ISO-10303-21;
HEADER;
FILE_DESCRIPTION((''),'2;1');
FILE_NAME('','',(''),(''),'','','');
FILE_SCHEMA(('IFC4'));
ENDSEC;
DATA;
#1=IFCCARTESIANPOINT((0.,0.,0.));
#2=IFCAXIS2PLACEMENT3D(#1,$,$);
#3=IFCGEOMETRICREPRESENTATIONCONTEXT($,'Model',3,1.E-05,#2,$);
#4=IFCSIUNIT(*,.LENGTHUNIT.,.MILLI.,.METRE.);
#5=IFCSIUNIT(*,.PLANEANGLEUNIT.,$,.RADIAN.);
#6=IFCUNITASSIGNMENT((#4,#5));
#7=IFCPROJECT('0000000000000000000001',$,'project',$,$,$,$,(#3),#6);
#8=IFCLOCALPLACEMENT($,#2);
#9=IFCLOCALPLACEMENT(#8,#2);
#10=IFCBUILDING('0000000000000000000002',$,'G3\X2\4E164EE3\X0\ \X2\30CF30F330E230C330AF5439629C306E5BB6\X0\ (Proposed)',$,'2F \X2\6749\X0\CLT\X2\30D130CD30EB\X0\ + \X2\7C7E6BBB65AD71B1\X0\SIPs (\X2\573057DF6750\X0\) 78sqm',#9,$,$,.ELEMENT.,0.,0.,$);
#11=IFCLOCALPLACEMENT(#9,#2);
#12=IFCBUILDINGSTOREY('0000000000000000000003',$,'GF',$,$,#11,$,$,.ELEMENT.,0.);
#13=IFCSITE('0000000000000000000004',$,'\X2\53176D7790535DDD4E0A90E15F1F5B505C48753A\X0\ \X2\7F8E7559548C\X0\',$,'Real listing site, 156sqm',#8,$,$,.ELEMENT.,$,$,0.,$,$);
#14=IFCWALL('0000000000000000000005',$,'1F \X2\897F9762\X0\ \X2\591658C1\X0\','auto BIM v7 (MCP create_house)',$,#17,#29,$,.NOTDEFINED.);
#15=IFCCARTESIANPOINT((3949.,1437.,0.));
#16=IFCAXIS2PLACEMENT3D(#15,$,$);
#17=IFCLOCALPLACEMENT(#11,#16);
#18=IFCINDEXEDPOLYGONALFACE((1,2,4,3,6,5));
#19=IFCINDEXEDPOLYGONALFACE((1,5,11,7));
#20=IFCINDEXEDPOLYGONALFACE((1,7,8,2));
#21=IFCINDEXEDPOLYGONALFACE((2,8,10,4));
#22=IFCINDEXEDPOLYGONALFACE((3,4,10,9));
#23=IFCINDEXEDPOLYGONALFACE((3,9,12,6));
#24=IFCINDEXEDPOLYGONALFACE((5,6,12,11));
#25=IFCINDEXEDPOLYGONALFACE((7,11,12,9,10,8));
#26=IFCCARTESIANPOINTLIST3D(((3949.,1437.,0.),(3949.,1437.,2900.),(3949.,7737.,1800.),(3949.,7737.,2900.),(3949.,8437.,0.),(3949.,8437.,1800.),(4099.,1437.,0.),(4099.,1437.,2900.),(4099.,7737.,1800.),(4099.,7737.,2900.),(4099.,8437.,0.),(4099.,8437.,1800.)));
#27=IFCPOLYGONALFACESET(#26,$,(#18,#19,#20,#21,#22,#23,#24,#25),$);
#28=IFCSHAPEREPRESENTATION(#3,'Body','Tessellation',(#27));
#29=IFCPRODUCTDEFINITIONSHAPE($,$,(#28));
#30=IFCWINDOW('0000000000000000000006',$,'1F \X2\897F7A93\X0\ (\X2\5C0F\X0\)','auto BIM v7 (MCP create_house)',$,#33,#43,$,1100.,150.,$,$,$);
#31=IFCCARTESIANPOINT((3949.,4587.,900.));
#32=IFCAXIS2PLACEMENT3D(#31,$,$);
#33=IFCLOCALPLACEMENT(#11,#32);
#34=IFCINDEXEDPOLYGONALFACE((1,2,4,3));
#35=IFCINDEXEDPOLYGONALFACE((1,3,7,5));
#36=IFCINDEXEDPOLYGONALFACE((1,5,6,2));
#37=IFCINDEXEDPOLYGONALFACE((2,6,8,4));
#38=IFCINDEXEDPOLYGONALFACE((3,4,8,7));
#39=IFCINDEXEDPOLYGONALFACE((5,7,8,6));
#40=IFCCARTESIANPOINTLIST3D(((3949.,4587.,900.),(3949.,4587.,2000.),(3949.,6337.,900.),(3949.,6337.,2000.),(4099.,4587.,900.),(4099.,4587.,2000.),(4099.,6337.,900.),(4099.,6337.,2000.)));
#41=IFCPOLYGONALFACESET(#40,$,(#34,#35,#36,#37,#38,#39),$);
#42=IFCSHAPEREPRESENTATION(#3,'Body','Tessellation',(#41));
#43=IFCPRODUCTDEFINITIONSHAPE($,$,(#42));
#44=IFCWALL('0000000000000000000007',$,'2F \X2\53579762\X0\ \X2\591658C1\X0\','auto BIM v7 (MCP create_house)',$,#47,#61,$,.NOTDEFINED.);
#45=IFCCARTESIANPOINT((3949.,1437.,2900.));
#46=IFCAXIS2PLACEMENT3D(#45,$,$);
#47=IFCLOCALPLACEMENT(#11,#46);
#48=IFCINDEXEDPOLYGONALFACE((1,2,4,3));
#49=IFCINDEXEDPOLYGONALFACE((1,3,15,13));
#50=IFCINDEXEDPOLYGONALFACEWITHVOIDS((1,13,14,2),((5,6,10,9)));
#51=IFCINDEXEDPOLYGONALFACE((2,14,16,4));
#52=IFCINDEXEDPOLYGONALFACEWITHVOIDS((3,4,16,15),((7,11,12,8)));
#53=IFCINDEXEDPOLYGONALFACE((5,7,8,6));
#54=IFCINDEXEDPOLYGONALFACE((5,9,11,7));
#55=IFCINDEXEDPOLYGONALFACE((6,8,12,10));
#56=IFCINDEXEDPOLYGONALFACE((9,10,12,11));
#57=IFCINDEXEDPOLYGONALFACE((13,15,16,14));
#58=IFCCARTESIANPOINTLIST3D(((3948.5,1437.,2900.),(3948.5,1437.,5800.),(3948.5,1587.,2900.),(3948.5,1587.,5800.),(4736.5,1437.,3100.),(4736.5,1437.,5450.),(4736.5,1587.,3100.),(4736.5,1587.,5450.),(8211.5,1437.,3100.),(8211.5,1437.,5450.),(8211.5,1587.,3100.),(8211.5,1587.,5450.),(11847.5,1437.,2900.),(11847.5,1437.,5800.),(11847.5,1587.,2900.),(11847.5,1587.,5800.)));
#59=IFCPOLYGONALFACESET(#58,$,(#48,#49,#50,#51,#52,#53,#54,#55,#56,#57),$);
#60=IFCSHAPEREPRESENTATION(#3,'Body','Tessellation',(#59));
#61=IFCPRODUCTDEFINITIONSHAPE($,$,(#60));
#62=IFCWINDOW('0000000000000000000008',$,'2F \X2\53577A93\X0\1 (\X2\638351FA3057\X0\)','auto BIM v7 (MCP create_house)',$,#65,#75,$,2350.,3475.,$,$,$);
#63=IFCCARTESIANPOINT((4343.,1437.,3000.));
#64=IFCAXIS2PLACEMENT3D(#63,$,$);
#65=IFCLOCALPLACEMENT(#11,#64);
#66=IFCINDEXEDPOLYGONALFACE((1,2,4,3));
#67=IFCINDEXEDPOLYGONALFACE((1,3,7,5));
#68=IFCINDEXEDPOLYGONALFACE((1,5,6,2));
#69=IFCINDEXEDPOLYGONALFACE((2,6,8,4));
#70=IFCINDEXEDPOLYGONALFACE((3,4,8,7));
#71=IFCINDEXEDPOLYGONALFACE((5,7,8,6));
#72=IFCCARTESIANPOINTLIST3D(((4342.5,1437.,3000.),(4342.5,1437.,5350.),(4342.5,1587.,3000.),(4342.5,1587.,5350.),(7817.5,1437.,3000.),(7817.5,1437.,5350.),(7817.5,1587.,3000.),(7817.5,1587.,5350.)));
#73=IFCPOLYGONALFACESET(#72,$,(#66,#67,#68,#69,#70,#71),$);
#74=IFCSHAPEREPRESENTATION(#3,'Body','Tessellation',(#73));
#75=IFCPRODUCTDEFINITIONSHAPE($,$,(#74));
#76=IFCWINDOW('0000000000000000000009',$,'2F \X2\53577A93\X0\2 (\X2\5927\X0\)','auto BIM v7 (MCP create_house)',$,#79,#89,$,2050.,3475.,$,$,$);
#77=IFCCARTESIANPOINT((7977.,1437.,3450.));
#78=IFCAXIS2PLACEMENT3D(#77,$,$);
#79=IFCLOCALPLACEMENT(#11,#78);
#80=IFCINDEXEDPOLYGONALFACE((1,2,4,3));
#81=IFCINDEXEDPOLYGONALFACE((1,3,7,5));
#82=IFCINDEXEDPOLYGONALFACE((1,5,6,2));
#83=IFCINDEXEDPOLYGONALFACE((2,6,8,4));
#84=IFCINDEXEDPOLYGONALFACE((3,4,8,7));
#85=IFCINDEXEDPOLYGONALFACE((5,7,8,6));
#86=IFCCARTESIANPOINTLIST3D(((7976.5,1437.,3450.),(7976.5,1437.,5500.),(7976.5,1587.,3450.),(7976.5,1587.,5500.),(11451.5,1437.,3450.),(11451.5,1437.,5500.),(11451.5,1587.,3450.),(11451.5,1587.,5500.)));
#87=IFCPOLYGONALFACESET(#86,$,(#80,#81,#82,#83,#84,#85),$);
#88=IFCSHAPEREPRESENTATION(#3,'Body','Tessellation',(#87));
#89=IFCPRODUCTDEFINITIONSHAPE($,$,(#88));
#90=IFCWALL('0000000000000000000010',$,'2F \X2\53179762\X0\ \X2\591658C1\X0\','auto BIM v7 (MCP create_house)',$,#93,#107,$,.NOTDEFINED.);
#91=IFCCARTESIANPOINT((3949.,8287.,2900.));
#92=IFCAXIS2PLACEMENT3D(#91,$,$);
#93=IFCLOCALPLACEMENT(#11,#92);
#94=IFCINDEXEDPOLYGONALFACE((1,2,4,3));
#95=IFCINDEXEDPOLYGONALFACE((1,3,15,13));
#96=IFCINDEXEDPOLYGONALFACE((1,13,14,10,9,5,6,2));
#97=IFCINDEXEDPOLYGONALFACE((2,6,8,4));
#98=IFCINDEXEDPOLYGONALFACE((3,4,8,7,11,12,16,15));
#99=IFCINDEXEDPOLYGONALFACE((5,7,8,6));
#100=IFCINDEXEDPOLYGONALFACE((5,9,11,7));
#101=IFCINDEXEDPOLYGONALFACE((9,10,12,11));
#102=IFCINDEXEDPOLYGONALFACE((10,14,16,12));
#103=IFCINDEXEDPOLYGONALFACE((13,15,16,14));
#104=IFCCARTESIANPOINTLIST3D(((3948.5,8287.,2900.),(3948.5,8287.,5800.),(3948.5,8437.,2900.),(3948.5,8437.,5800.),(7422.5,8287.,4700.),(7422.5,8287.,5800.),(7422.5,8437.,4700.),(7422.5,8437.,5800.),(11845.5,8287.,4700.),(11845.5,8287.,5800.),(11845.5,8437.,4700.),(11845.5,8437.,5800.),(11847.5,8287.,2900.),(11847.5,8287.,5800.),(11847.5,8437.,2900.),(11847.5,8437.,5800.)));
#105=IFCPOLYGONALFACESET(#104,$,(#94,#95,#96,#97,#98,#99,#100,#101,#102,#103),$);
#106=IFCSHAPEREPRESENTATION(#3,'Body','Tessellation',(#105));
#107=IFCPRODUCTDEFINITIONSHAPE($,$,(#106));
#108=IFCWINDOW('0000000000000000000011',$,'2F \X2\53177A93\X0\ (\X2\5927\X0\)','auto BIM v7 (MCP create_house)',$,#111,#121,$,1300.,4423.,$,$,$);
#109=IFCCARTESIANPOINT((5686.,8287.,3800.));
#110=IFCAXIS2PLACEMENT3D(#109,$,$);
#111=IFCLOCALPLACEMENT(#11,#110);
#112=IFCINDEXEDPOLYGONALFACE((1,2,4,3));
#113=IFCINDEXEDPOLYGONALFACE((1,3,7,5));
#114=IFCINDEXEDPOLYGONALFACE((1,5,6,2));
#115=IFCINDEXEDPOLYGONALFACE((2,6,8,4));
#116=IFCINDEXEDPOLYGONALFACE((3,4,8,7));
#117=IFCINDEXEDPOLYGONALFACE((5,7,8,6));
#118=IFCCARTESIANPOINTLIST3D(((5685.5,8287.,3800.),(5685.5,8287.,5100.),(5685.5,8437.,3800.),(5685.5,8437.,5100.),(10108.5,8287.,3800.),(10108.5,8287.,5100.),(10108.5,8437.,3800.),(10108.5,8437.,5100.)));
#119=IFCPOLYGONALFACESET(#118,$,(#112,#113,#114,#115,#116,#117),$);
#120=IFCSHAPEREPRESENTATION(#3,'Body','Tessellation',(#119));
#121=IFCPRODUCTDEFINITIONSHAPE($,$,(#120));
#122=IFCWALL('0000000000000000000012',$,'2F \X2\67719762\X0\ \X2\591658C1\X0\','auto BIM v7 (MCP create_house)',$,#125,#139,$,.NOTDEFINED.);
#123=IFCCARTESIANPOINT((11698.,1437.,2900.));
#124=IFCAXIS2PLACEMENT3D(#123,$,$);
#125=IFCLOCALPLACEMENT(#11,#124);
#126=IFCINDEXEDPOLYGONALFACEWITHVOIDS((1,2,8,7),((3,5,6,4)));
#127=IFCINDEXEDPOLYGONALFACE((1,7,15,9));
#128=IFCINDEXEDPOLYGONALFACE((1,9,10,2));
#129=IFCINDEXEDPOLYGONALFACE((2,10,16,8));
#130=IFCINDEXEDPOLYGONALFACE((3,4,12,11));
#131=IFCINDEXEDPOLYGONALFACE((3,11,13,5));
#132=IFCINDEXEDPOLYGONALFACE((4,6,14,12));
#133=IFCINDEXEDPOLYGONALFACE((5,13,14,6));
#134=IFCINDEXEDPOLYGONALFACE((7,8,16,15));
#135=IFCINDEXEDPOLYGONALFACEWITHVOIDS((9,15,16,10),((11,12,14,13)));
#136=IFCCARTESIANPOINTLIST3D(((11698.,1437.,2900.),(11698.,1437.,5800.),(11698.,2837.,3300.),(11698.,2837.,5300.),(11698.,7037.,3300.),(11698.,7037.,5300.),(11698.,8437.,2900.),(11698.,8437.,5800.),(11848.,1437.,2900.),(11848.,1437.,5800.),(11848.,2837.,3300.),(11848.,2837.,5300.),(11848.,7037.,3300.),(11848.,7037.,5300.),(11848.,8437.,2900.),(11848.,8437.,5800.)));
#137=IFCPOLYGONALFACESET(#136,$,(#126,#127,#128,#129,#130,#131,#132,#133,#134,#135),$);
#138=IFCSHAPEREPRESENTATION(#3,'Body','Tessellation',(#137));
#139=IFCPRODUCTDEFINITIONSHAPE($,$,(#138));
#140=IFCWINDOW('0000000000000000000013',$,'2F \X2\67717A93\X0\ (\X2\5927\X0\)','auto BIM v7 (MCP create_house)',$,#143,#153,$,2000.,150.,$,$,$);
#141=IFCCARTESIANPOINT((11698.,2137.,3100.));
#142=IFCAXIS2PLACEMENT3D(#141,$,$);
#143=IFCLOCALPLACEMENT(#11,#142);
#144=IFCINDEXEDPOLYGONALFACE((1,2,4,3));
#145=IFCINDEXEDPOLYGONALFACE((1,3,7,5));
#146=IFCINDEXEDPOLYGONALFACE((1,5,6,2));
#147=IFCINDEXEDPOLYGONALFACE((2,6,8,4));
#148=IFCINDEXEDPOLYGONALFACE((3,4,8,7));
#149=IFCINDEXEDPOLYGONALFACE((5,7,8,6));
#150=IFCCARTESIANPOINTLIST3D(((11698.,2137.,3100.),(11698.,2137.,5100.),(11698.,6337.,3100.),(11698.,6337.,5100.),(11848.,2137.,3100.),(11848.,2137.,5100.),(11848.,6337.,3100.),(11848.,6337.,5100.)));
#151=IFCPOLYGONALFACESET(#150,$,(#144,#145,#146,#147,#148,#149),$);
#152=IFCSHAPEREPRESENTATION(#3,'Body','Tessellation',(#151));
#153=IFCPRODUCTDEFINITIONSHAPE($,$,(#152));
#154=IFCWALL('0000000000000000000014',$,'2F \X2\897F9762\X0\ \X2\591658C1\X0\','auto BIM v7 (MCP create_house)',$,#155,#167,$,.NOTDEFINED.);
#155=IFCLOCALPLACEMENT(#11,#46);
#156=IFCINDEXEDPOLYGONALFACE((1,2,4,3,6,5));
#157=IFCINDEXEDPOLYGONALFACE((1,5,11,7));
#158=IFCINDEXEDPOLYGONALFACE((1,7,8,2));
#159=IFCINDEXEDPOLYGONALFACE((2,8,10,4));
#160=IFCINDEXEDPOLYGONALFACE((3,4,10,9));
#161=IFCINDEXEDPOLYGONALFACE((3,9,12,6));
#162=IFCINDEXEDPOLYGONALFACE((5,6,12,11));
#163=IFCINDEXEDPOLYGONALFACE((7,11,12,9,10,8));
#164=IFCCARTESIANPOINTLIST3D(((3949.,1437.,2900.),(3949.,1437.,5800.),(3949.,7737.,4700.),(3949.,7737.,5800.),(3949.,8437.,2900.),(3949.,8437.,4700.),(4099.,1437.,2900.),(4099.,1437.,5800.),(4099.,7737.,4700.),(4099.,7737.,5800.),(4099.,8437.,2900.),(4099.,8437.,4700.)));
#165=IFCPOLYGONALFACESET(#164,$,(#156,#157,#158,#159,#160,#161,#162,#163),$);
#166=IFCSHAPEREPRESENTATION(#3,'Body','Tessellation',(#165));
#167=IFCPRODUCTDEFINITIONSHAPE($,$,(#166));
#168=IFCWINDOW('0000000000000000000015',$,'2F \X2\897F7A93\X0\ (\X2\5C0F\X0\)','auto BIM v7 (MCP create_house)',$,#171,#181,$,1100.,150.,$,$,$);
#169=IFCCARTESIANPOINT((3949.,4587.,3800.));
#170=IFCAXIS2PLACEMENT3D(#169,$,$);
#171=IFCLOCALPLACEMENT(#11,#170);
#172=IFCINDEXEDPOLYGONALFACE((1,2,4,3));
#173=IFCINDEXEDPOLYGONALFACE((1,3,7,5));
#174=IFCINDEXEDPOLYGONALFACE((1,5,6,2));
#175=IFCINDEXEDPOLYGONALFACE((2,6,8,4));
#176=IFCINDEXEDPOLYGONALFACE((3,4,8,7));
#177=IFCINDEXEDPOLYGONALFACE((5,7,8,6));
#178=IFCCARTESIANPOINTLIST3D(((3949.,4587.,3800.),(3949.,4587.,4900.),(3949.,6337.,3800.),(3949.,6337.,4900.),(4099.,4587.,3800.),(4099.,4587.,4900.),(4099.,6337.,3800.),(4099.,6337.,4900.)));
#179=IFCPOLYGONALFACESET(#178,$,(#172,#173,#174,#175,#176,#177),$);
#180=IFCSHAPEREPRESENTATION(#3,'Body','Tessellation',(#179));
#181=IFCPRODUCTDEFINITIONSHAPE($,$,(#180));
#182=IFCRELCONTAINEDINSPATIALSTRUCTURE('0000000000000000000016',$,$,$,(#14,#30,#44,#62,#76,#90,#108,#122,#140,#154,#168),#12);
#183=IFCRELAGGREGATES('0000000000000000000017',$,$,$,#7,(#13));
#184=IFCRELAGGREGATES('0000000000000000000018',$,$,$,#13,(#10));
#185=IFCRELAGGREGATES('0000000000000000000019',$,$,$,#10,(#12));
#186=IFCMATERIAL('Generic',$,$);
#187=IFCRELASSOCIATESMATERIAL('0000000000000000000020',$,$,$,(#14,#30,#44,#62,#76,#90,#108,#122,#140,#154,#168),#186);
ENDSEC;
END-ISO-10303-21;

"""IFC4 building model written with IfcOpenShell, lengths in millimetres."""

from ifc_helpers import new_model, si_unit, frame, frame_2d, origin, place, context, project, spatial, rectangle, extrude, material, element, fill, save


model = new_model("IFC4")

# Units and contexts
model_context = context("Model", 3, precision=1e-05, world=origin())
ifc_project = project(units=[si_unit("LENGTHUNIT", "METRE", prefix="MILLI"), si_unit("PLANEANGLEUNIT", "RADIAN")], contexts=[model_context])

# Site, building, storey
site_placement = place(None, origin())
site = spatial("IfcSite", under=ifc_project, at=site_placement, Name="北海道川上郡弟子屈町 美留和", ObjectType="Real listing site, 156sqm", CompositionType="ELEMENT", RefElevation=0.0)
building_placement = place(site_placement, origin())
building = spatial("IfcBuilding", under=site, at=building_placement, Name="G3世代 ハンモック吹抜の家 (Proposed)", ObjectType="2F 杉CLTパネル + 籾殻断熱SIPs (地域材) 78sqm", CompositionType="ELEMENT", ElevationOfRefHeight=0.0, ElevationOfTerrain=0.0)
storey_placement = place(building_placement, origin())
storey = spatial("IfcBuildingStorey", under=building, at=storey_placement, Name="GF", CompositionType="ELEMENT", Elevation=0.0)

# Shared definitions
ifc_material = material(Name="Generic")

# Wall, opening, window
wall_1_placement = place(storey_placement, frame((3949.0, 1437.0, 0.0)))
wall_1 = element("IfcWall", 1, at=wall_1_placement, inside=storey, material=ifc_material, Name="1F 西面 外壁", Description="auto BIM v7 (MCP create_house)", PredefinedType="NOTDEFINED", context=model_context, shape_type="SweptSolid", body=[
    extrude(rectangle(XDim=150.0, YDim=7000.0, at=frame_2d((75.0, 3500.0))), frame((3949.0, 1437.0, 0.0)), (0.0, 0.0, 1.0), 2900.0),
])
opening_1_placement = place(storey_placement, frame((3949.0, 4587.0, 900.0)))
opening_1 = element("IfcOpeningElement", 2, at=opening_1_placement, cuts=wall_1, PredefinedType="NOTDEFINED", context=model_context, shape_type="SweptSolid", body=[
    extrude(rectangle(XDim=150.0, YDim=1750.0, at=frame_2d((75.0, 875.0))), frame((3949.0, 4587.0, 900.0)), (0.0, 0.0, 1.0), 1100.0),
])
window_1_placement = place(storey_placement, frame((3949.0, 4587.0, 900.0)))
window_1 = element("IfcWindow", 3, at=window_1_placement, inside=storey, material=ifc_material, Name="1F 西窓 (小)", Description="auto BIM v7 (MCP create_house)", OverallHeight=1100.0, OverallWidth=150.0, context=model_context, shape_type="SweptSolid", body=[
    extrude(rectangle(XDim=150.0, YDim=1750.0, at=frame_2d((75.0, 875.0))), frame((3949.0, 4587.0, 900.0)), (0.0, 0.0, 1.0), 1100.0),
])
fill(opening_1, window_1)

# Wall, openings, windows
wall_2_placement = place(storey_placement, frame((3949.0, 1437.0, 2900.0)))
wall_2 = element("IfcWall", 4, at=wall_2_placement, inside=storey, material=ifc_material, Name="2F 南面 外壁", Description="auto BIM v7 (MCP create_house)", PredefinedType="NOTDEFINED", context=model_context, shape_type="SweptSolid", body=[
    extrude(rectangle(XDim=7899.0, YDim=150.0, at=frame_2d((3949.0, 75.0))), frame((3949.0, 1437.0, 2900.0)), (0.0, 0.0, 1.0), 2900.0),
])
opening_2_placement = place(storey_placement, frame((4343.0, 1437.0, 3000.0)))
opening_2 = element("IfcOpeningElement", 5, at=opening_2_placement, cuts=wall_2, PredefinedType="NOTDEFINED", context=model_context, shape_type="SweptSolid", body=[
    extrude(rectangle(XDim=3475.0, YDim=150.0, at=frame_2d((1737.0, 75.0))), frame((4343.0, 1437.0, 3000.0)), (0.0, 0.0, 1.0), 2350.0),
])
opening_3_placement = place(storey_placement, frame((7977.0, 1437.0, 3450.0)))
opening_3 = element("IfcOpeningElement", 6, at=opening_3_placement, cuts=wall_2, PredefinedType="NOTDEFINED", context=model_context, shape_type="SweptSolid", body=[
    extrude(rectangle(XDim=3475.0, YDim=150.0, at=frame_2d((1737.0, 75.0))), frame((7977.0, 1437.0, 3450.0)), (0.0, 0.0, 1.0), 2050.0),
])
window_2_placement = place(storey_placement, frame((4343.0, 1437.0, 3000.0)))
window_2 = element("IfcWindow", 7, at=window_2_placement, inside=storey, material=ifc_material, Name="2F 南窓1 (掃出し)", Description="auto BIM v7 (MCP create_house)", OverallHeight=2350.0, OverallWidth=3475.0, context=model_context, shape_type="SweptSolid", body=[
    extrude(rectangle(XDim=3475.0, YDim=150.0, at=frame_2d((1737.0, 75.0))), frame((4343.0, 1437.0, 3000.0)), (0.0, 0.0, 1.0), 2350.0),
])
fill(opening_2, window_2)
window_3_placement = place(storey_placement, frame((7977.0, 1437.0, 3450.0)))
window_3 = element("IfcWindow", 8, at=window_3_placement, inside=storey, material=ifc_material, Name="2F 南窓2 (大)", Description="auto BIM v7 (MCP create_house)", OverallHeight=2050.0, OverallWidth=3475.0, context=model_context, shape_type="SweptSolid", body=[
    extrude(rectangle(XDim=3475.0, YDim=150.0, at=frame_2d((1737.0, 75.0))), frame((7977.0, 1437.0, 3450.0)), (0.0, 0.0, 1.0), 2050.0),
])
fill(opening_3, window_3)

# Walls, openings, windows
wall_3_placement = place(storey_placement, frame((3949.0, 8287.0, 2900.0)))
wall_3 = element("IfcWall", 9, at=wall_3_placement, inside=storey, material=ifc_material, Name="2F 北面 外壁", Description="auto BIM v7 (MCP create_house)", PredefinedType="NOTDEFINED", context=model_context, shape_type="SweptSolid", body=[
    extrude(rectangle(XDim=7899.0, YDim=150.0, at=frame_2d((3949.0, 75.0))), frame((3949.0, 8287.0, 2900.0)), (0.0, 0.0, 1.0), 2900.0),
])
opening_4_placement = place(storey_placement, frame((5686.0, 8287.0, 3800.0)))
opening_4 = element("IfcOpeningElement", 10, at=opening_4_placement, cuts=wall_3, PredefinedType="NOTDEFINED", context=model_context, shape_type="SweptSolid", body=[
    extrude(rectangle(XDim=4423.0, YDim=150.0, at=frame_2d((2211.0, 75.0))), frame((5686.0, 8287.0, 3800.0)), (0.0, 0.0, 1.0), 1300.0),
])
window_4_placement = place(storey_placement, frame((5686.0, 8287.0, 3800.0)))
window_4 = element("IfcWindow", 11, at=window_4_placement, inside=storey, material=ifc_material, Name="2F 北窓 (大)", Description="auto BIM v7 (MCP create_house)", OverallHeight=1300.0, OverallWidth=4423.0, context=model_context, shape_type="SweptSolid", body=[
    extrude(rectangle(XDim=4423.0, YDim=150.0, at=frame_2d((2211.0, 75.0))), frame((5686.0, 8287.0, 3800.0)), (0.0, 0.0, 1.0), 1300.0),
])
fill(opening_4, window_4)
wall_4_placement = place(storey_placement, frame((11698.0, 1437.0, 2900.0)))
wall_4 = element("IfcWall", 12, at=wall_4_placement, inside=storey, material=ifc_material, Name="2F 東面 外壁", Description="auto BIM v7 (MCP create_house)", PredefinedType="NOTDEFINED", context=model_context, shape_type="SweptSolid", body=[
    extrude(rectangle(XDim=150.0, YDim=7000.0, at=frame_2d((75.0, 3500.0))), frame((11698.0, 1437.0, 2900.0)), (0.0, 0.0, 1.0), 2900.0),
])
opening_5_placement = place(storey_placement, frame((11698.0, 2137.0, 3100.0)))
opening_5 = element("IfcOpeningElement", 13, at=opening_5_placement, cuts=wall_4, PredefinedType="NOTDEFINED", context=model_context, shape_type="SweptSolid", body=[
    extrude(rectangle(XDim=150.0, YDim=4200.0, at=frame_2d((75.0, 2100.0))), frame((11698.0, 2137.0, 3100.0)), (0.0, 0.0, 1.0), 2000.0),
])
window_5_placement = place(storey_placement, frame((11698.0, 2137.0, 3100.0)))
window_5 = element("IfcWindow", 14, at=window_5_placement, inside=storey, material=ifc_material, Name="2F 東窓 (大)", Description="auto BIM v7 (MCP create_house)", OverallHeight=2000.0, OverallWidth=150.0, context=model_context, shape_type="SweptSolid", body=[
    extrude(rectangle(XDim=150.0, YDim=4200.0, at=frame_2d((75.0, 2100.0))), frame((11698.0, 2137.0, 3100.0)), (0.0, 0.0, 1.0), 2000.0),
])
fill(opening_5, window_5)
wall_5_placement = place(storey_placement, frame((3949.0, 1437.0, 2900.0)))
wall_5 = element("IfcWall", 15, at=wall_5_placement, inside=storey, material=ifc_material, Name="2F 西面 外壁", Description="auto BIM v7 (MCP create_house)", PredefinedType="NOTDEFINED", context=model_context, shape_type="SweptSolid", body=[
    extrude(rectangle(XDim=150.0, YDim=7000.0, at=frame_2d((75.0, 3500.0))), frame((3949.0, 1437.0, 2900.0)), (0.0, 0.0, 1.0), 2900.0),
])
opening_6_placement = place(storey_placement, frame((3949.0, 4587.0, 3800.0)))
opening_6 = element("IfcOpeningElement", 16, at=opening_6_placement, cuts=wall_5, PredefinedType="NOTDEFINED", context=model_context, shape_type="SweptSolid", body=[
    extrude(rectangle(XDim=150.0, YDim=1750.0, at=frame_2d((75.0, 875.0))), frame((3949.0, 4587.0, 3800.0)), (0.0, 0.0, 1.0), 1100.0),
])
window_6_placement = place(storey_placement, frame((3949.0, 4587.0, 3800.0)))
window_6 = element("IfcWindow", 17, at=window_6_placement, inside=storey, material=ifc_material, Name="2F 西窓 (小)", Description="auto BIM v7 (MCP create_house)", OverallHeight=1100.0, OverallWidth=150.0, context=model_context, shape_type="SweptSolid", body=[
    extrude(rectangle(XDim=150.0, YDim=1750.0, at=frame_2d((75.0, 875.0))), frame((3949.0, 4587.0, 3800.0)), (0.0, 0.0, 1.0), 1100.0),
])
fill(opening_6, window_6)

save(model, "model.ifc")
